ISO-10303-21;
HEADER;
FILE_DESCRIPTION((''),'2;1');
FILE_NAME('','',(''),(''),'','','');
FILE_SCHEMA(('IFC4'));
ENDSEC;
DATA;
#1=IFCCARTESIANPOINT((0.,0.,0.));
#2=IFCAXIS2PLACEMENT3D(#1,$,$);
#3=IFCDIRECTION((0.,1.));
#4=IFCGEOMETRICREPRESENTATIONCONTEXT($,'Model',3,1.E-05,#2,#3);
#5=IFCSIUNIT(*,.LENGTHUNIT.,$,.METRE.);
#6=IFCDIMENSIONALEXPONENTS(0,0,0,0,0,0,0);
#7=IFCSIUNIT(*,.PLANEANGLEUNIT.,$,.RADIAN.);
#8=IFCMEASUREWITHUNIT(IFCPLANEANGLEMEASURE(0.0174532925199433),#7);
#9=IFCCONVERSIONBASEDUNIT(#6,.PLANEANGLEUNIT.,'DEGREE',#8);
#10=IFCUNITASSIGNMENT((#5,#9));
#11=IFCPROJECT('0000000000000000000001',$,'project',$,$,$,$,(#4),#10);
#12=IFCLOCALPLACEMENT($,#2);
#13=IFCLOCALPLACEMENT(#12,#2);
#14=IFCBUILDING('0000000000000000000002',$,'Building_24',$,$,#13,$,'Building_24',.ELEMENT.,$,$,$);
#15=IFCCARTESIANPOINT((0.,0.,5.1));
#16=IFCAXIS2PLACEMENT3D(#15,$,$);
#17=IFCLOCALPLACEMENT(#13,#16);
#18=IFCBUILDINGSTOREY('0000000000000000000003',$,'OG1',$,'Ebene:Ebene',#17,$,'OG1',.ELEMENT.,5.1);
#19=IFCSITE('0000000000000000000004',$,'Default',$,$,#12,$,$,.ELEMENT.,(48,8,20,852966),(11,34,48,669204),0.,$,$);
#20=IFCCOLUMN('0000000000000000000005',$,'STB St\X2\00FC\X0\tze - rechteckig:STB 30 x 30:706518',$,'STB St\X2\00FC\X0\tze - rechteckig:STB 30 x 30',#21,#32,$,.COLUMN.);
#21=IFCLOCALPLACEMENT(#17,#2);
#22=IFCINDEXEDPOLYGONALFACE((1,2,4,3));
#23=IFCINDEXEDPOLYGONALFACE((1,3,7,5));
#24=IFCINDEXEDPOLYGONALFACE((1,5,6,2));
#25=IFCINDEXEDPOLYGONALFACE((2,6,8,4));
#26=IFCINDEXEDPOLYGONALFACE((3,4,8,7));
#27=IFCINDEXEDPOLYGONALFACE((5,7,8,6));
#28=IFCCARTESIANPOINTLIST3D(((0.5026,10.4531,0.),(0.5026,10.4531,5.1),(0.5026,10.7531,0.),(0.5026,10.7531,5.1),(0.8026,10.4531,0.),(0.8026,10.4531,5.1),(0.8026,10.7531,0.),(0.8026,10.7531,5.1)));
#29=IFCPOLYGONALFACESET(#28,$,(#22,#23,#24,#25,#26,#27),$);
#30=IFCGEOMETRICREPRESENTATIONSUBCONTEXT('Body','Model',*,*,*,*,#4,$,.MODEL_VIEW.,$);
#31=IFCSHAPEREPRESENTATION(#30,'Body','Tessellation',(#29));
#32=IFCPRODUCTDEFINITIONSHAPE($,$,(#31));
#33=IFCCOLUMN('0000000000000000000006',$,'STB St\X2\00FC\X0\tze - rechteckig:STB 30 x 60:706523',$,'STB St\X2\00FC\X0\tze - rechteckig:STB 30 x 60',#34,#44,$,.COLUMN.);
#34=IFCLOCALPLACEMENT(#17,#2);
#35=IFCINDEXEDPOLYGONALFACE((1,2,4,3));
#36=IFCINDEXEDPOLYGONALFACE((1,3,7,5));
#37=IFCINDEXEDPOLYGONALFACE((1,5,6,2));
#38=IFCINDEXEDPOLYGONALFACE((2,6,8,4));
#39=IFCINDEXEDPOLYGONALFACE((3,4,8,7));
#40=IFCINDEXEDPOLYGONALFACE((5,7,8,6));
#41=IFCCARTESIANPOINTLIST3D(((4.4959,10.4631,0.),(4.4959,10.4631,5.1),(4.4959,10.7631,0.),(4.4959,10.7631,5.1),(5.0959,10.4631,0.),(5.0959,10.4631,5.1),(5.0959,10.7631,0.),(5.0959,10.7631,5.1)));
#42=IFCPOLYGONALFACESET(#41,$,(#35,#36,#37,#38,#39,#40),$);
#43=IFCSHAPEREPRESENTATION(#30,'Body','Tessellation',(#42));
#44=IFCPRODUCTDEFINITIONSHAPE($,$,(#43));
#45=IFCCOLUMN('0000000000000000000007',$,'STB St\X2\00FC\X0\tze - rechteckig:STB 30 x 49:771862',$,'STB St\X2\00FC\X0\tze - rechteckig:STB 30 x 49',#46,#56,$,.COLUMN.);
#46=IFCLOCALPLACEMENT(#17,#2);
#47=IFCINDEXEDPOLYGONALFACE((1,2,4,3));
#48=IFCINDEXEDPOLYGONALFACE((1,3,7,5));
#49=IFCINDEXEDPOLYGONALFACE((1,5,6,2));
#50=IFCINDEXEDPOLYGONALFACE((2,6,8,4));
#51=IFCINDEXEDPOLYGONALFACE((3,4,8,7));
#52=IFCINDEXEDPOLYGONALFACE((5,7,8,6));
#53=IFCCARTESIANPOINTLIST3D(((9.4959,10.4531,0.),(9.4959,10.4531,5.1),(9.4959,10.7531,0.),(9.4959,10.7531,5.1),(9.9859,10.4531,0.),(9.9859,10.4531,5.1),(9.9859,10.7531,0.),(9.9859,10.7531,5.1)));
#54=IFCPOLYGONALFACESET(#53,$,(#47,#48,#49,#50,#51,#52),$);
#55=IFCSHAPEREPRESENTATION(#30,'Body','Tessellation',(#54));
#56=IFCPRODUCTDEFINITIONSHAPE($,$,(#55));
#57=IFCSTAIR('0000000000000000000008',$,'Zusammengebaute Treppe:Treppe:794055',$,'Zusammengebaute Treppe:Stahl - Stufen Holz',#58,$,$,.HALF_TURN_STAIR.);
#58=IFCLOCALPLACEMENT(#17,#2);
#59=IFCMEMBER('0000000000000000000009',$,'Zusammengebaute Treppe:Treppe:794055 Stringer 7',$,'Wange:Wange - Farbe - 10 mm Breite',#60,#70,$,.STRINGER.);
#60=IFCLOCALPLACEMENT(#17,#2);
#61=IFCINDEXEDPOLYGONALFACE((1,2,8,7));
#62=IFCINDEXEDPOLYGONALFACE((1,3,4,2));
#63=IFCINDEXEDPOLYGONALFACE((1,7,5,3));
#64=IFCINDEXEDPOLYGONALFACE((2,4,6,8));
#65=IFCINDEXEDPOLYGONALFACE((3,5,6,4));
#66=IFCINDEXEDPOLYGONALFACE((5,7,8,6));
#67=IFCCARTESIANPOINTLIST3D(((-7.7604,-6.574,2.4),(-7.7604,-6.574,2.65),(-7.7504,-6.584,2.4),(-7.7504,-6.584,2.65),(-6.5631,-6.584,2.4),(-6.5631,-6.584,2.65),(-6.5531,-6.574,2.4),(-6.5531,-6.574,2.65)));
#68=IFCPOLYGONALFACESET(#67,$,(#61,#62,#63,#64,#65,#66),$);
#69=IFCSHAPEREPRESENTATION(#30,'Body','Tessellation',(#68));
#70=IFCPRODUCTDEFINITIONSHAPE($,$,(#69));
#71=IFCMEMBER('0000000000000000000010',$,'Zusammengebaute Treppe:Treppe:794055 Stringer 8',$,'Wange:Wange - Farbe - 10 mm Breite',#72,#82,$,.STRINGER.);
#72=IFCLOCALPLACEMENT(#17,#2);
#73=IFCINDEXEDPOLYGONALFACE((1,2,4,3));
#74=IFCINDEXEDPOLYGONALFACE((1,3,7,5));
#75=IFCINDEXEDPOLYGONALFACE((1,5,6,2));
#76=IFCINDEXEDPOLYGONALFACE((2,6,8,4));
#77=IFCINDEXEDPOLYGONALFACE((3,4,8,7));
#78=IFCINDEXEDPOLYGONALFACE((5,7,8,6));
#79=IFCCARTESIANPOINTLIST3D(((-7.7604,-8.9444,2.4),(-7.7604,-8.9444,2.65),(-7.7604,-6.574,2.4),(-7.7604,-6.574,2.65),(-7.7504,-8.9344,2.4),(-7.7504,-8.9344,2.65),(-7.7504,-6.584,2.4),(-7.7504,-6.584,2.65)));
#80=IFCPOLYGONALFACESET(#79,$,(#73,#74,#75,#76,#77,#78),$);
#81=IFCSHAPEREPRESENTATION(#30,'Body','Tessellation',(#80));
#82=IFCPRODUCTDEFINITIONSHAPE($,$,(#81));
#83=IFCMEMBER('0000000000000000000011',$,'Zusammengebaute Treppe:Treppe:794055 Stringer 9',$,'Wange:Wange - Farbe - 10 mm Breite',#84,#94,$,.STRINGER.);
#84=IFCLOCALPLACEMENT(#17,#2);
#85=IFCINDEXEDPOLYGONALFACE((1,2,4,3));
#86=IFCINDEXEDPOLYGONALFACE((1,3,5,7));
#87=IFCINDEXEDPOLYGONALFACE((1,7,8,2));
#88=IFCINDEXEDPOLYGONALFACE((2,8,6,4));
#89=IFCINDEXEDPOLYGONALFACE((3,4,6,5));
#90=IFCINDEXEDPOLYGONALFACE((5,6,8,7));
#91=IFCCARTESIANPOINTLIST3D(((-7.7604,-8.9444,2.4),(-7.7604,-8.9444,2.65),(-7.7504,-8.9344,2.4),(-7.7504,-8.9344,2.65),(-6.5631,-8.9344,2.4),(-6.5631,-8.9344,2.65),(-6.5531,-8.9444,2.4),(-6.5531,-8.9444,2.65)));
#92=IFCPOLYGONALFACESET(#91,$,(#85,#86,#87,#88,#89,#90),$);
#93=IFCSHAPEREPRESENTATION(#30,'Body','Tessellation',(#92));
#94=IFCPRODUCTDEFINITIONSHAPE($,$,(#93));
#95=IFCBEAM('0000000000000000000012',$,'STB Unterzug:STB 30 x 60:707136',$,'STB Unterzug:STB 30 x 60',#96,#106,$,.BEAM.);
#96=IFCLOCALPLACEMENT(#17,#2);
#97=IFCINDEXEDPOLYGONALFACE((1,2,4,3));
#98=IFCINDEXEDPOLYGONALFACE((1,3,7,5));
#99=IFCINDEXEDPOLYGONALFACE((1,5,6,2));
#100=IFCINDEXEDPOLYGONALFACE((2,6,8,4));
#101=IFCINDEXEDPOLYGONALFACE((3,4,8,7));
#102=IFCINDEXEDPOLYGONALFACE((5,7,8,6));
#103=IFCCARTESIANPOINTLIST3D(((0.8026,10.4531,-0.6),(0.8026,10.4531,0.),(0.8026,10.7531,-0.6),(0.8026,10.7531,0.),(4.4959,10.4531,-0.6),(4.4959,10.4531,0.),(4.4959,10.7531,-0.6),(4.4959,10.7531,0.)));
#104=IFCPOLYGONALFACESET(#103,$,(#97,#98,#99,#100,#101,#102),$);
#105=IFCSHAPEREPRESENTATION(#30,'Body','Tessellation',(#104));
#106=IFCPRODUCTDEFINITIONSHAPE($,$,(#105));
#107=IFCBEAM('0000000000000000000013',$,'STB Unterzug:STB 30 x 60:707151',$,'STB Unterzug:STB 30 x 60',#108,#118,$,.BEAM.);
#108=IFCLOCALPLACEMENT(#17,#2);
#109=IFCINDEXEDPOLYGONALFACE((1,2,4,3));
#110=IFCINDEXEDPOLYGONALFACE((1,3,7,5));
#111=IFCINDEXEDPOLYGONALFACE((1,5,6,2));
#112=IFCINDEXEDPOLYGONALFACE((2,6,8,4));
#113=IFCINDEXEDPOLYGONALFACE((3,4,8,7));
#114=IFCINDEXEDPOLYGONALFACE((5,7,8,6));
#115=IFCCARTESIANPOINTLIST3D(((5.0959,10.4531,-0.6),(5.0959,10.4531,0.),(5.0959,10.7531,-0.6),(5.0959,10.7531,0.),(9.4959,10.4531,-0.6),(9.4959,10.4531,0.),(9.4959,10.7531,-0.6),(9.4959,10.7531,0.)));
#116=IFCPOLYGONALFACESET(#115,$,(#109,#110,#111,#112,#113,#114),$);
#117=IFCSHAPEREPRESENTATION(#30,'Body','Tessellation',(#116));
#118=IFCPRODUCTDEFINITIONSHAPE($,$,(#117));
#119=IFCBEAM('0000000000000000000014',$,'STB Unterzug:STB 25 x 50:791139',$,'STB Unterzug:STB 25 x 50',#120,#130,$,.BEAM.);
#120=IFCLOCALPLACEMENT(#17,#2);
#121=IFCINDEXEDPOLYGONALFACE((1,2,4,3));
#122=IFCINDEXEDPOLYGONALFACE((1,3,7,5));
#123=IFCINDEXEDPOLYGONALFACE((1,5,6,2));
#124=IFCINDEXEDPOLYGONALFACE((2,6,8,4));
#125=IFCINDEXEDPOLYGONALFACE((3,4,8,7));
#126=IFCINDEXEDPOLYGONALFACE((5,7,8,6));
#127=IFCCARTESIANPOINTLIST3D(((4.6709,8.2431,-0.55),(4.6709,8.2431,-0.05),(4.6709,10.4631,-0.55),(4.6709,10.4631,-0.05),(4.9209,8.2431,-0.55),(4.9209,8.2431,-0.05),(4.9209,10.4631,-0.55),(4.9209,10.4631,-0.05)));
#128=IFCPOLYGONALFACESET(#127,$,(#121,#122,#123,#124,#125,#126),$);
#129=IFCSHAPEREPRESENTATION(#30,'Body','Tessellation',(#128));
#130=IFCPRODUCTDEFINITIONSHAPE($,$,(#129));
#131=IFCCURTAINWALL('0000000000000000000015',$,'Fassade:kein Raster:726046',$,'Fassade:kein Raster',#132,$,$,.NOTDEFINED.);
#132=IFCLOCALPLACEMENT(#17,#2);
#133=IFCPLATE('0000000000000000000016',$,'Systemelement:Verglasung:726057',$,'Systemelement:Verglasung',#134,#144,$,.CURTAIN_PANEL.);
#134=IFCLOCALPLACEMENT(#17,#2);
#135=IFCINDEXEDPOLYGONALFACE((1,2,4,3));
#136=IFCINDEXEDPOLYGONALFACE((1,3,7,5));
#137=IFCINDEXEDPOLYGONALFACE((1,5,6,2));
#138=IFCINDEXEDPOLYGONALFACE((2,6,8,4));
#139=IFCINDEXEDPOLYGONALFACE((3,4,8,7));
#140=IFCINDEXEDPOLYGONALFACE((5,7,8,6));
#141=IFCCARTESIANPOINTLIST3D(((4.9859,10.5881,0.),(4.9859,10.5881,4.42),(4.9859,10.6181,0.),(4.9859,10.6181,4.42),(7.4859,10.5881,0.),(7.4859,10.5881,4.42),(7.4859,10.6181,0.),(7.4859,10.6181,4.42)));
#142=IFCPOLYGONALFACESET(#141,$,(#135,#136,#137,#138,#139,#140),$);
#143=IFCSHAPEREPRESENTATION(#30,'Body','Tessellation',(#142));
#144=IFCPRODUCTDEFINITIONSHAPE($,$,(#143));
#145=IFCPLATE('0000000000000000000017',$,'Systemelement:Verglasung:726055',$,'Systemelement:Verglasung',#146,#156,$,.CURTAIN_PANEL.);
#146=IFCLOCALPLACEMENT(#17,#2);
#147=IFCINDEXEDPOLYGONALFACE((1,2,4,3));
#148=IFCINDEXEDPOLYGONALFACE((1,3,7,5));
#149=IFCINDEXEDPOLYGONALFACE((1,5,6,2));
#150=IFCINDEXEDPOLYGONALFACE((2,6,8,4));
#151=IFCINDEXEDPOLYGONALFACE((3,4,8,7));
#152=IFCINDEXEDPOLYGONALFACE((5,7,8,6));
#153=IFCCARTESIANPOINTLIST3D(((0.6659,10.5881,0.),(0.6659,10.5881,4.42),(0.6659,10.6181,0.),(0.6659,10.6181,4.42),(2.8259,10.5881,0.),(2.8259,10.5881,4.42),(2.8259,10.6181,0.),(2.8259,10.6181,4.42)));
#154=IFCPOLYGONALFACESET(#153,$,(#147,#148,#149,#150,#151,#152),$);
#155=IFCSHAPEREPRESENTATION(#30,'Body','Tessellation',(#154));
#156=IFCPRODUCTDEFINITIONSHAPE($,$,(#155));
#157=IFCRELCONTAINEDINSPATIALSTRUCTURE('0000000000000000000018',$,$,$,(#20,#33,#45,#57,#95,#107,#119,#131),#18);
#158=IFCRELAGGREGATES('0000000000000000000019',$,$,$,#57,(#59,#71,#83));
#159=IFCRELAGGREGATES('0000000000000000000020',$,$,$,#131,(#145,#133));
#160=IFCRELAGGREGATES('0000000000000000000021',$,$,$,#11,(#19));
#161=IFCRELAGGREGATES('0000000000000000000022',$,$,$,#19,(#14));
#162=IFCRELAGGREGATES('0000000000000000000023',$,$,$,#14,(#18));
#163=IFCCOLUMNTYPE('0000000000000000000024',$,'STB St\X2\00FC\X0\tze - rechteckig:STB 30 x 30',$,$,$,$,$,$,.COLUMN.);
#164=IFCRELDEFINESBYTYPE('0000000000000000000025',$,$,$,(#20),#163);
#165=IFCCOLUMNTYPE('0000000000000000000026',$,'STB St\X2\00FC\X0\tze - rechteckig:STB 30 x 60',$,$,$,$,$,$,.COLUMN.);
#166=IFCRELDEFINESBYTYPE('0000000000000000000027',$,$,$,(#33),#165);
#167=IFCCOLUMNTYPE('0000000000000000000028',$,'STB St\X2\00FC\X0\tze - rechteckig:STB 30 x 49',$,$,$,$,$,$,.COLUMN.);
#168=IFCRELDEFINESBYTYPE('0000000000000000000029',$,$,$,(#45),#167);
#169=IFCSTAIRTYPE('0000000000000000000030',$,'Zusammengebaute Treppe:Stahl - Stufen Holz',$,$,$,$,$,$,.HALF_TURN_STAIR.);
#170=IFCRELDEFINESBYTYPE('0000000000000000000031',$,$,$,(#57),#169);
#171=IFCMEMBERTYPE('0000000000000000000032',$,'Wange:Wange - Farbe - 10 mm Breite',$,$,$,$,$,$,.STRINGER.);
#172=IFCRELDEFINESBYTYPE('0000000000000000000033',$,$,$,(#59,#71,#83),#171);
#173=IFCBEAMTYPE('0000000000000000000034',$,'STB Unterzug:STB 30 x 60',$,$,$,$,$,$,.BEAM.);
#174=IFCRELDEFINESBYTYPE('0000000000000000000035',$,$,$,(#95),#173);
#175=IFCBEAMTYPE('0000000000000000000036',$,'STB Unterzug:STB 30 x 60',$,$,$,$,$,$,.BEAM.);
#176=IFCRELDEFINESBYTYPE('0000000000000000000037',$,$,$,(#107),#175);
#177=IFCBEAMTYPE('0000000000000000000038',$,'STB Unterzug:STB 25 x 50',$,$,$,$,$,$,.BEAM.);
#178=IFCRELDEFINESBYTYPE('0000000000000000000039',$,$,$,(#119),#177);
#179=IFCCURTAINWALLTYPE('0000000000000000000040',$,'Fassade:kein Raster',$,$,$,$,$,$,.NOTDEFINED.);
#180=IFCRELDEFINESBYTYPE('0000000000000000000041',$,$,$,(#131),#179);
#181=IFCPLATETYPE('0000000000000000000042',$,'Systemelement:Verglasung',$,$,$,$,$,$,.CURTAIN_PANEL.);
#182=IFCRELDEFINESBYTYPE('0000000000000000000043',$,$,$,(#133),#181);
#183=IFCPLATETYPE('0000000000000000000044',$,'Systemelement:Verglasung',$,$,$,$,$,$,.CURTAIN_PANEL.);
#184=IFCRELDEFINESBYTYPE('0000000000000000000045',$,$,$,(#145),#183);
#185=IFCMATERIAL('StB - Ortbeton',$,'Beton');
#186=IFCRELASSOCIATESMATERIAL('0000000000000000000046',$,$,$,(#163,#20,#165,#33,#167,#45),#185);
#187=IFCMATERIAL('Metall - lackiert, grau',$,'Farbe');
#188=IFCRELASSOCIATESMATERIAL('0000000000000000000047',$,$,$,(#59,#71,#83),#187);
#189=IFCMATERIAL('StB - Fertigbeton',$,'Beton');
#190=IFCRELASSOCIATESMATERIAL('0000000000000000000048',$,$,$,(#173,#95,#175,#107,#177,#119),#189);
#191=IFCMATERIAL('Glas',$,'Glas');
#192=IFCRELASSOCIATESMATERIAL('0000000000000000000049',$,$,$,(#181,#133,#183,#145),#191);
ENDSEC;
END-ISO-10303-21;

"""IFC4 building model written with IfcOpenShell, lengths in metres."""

from ifc_helpers import new_model, entity, si_unit, converted_unit, direction, frame, origin, place, context, subcontext, project, spatial, indexed_curve, outline, extrude, source, transform, mapped, material, type_object, type_shapes, element, aggregate, save


model = new_model("IFC4")

# Units and contexts
model_context = context("Model", 3, precision=1e-05, world=origin(), true_north=direction((0.0, 1.0)))
body_context = subcontext(model_context, "Body", "Model", "MODEL_VIEW")
ifc_project = project(units=[si_unit("LENGTHUNIT", "METRE"), converted_unit("PLANEANGLEUNIT", "DEGREE", entity("IfcPlaneAngleMeasure", 0.0174532925199433), si_unit("PLANEANGLEUNIT", "RADIAN"), dimensions=[0, 0, 0, 0, 0, 0, 0])], contexts=[model_context])

# Site, building, storey
site_placement = place(None, origin())
site = spatial("IfcSite", under=ifc_project, at=site_placement, Name="Default", CompositionType="ELEMENT", RefLatitude=(48, 8, 20, 852966), RefLongitude=(11, 34, 48, 669204), RefElevation=0.0)
building_placement = place(site_placement, origin())
building = spatial("IfcBuilding", under=site, at=building_placement, Name="Building_24", LongName="Building_24", CompositionType="ELEMENT")
storey_placement = place(building_placement, frame((0.0, 0.0, 5.1)))
storey = spatial("IfcBuildingStorey", under=building, at=storey_placement, Name="OG1", ObjectType="Ebene:Ebene", LongName="OG1", CompositionType="ELEMENT", Elevation=5.1)

# Columns
ifc_material_1 = material(Name="StB - Ortbeton", Category="Beton")
column_type_1 = type_object("IfcColumnType", Name="STB Stütze - rechteckig:STB 30 x 30", PredefinedType="COLUMN", material=ifc_material_1)
shared_shape_1 = source(origin(), body_context, "Body", "SweptSolid", [
    extrude(outline(indexed_curve([(-0.15, -0.15), (0.15, -0.15), (0.15, 0.15), (-0.15, 0.15), (-0.15, -0.15)], self_intersect=False)), frame((0.0, 0.0, 5.1), z_axis=(0.0, 0.0, 1.0), x_axis=(-1.0, 0.0, 0.0)), (0.0, 0.0, 1.0), 5.1),
])
type_shapes(column_type_1, [shared_shape_1])
column_1_placement = place(storey_placement, frame((0.6526, 10.6031, -5.1)))
element("IfcColumn", 1, at=column_1_placement, inside=storey, type_object=column_type_1, material=ifc_material_1, Name="STB Stütze - rechteckig:STB 30 x 30:706518", ObjectType="STB Stütze - rechteckig:STB 30 x 30", PredefinedType="COLUMN", context=body_context, shape_type="MappedRepresentation", body=[
    mapped(shared_shape_1, transform((0.0, 0.0, 0.0), scale=1.0)),
])
column_type_2 = type_object("IfcColumnType", Name="STB Stütze - rechteckig:STB 30 x 60", PredefinedType="COLUMN", material=ifc_material_1)
shared_shape_2 = source(origin(), body_context, "Body", "SweptSolid", [
    extrude(outline(indexed_curve([(-0.3, -0.15), (0.3, -0.15), (0.3, 0.15), (-0.3, 0.15), (-0.3, -0.15)], self_intersect=False)), frame((0.0, 0.0, 5.1), z_axis=(0.0, 0.0, 1.0), x_axis=(-1.0, 0.0, 0.0)), (0.0, 0.0, 1.0), 5.1),
])
type_shapes(column_type_2, [shared_shape_2])
column_2_placement = place(storey_placement, frame((4.7959, 10.6131, -5.1)))
element("IfcColumn", 2, at=column_2_placement, inside=storey, type_object=column_type_2, material=ifc_material_1, Name="STB Stütze - rechteckig:STB 30 x 60:706523", ObjectType="STB Stütze - rechteckig:STB 30 x 60", PredefinedType="COLUMN", context=body_context, shape_type="MappedRepresentation", body=[
    mapped(shared_shape_2, transform((0.0, 0.0, 0.0), scale=1.0)),
])
column_type_3 = type_object("IfcColumnType", Name="STB Stütze - rechteckig:STB 30 x 49", PredefinedType="COLUMN", material=ifc_material_1)
shared_shape_3 = source(origin(), body_context, "Body", "SweptSolid", [
    extrude(outline(indexed_curve([(-0.245, -0.15), (0.245, -0.15), (0.245, 0.15), (-0.245, 0.15), (-0.245, -0.15)], self_intersect=False)), frame((0.0, 0.0, 5.1), z_axis=(0.0, 0.0, 1.0), x_axis=(-1.0, 0.0, 0.0)), (0.0, 0.0, 1.0), 5.1),
])
type_shapes(column_type_3, [shared_shape_3])
column_3_placement = place(storey_placement, frame((9.7409, 10.6031, -5.1)))
element("IfcColumn", 3, at=column_3_placement, inside=storey, type_object=column_type_3, material=ifc_material_1, Name="STB Stütze - rechteckig:STB 30 x 49:771862", ObjectType="STB Stütze - rechteckig:STB 30 x 49", PredefinedType="COLUMN", context=body_context, shape_type="MappedRepresentation", body=[
    mapped(shared_shape_3, transform((0.0, 0.0, 0.0), scale=1.0)),
])

# Stair, members
stair_type = type_object("IfcStairType", Name="Zusammengebaute Treppe:Stahl - Stufen Holz", PredefinedType="HALF_TURN_STAIR")
stair_placement = place(storey_placement, origin())
stair = element("IfcStair", 4, at=stair_placement, inside=storey, type_object=stair_type, Name="Zusammengebaute Treppe:Treppe:794055", ObjectType="Zusammengebaute Treppe:Stahl - Stufen Holz", PredefinedType="HALF_TURN_STAIR")
ifc_material_2 = material(Name="Metall - lackiert, grau", Category="Farbe")
member_type = type_object("IfcMemberType", Name="Wange:Wange - Farbe - 10 mm Breite", PredefinedType="STRINGER")
member_1_placement = place(stair_placement, origin())
member_1 = element("IfcMember", 5, at=member_1_placement, type_object=member_type, material=ifc_material_2, Name="Zusammengebaute Treppe:Treppe:794055 Stringer 7", ObjectType="Wange:Wange - Farbe - 10 mm Breite", PredefinedType="STRINGER", context=body_context, shape_type="SweptSolid", body=[
    extrude(outline(indexed_curve([(-0.6037, -0.005), (0.6037, -0.005), (0.5937, 0.005), (-0.5937, 0.005), (-0.6037, -0.005)], self_intersect=False)), frame((-7.1568, -6.579, 2.4), z_axis=(0.0, 0.0, 1.0), x_axis=(-1.0, 0.0, 0.0)), (0.0, 0.0, 1.0), 0.25),
])
member_2_placement = place(stair_placement, origin())
member_2 = element("IfcMember", 6, at=member_2_placement, type_object=member_type, material=ifc_material_2, Name="Zusammengebaute Treppe:Treppe:794055 Stringer 8", ObjectType="Wange:Wange - Farbe - 10 mm Breite", PredefinedType="STRINGER", context=body_context, shape_type="SweptSolid", body=[
    extrude(outline(indexed_curve([(-1.1852, -0.005), (1.1852, -0.005), (1.1752, 0.005), (-1.1752, 0.005), (-1.1852, -0.005)], self_intersect=False)), frame((-7.7554, -7.7592, 2.4), z_axis=(0.0, 0.0, 1.0), x_axis=(0.0, -1.0, 0.0)), (0.0, 0.0, 1.0), 0.25),
])
member_3_placement = place(stair_placement, origin())
member_3 = element("IfcMember", 7, at=member_3_placement, type_object=member_type, material=ifc_material_2, Name="Zusammengebaute Treppe:Treppe:794055 Stringer 9", ObjectType="Wange:Wange - Farbe - 10 mm Breite", PredefinedType="STRINGER", context=body_context, shape_type="SweptSolid", body=[
    extrude(outline(indexed_curve([(-0.6037, -0.005), (0.6037, -0.005), (0.5937, 0.005), (-0.5937, 0.005), (-0.6037, -0.005)], self_intersect=False)), frame((-7.1568, -8.9394, 2.4)), (0.0, 0.0, 1.0), 0.25),
])
aggregate(stair, [member_1, member_2, member_3])

# Beams
ifc_material_3 = material(Name="StB - Fertigbeton", Category="Beton")
beam_type_1 = type_object("IfcBeamType", Name="STB Unterzug:STB 30 x 60", PredefinedType="BEAM", material=ifc_material_3)
shared_shape_4 = source(origin(), body_context, "Body", "SweptSolid", [
    extrude(outline(indexed_curve([(-1.8467, -0.15), (1.8467, -0.15), (1.8467, 0.15), (-1.8467, 0.15), (-1.8467, -0.15)], self_intersect=False)), frame((-0.18, 0.0, -0.3), z_axis=(0.0, 0.0, 1.0), x_axis=(-1.0, 0.0, 0.0)), (0.0, 0.0, 1.0), 0.6),
])
type_shapes(beam_type_1, [shared_shape_4])
beam_1_placement = place(storey_placement, frame((2.8293, 10.6031, -0.3)))
element("IfcBeam", 8, at=beam_1_placement, inside=storey, type_object=beam_type_1, material=ifc_material_3, Name="STB Unterzug:STB 30 x 60:707136", ObjectType="STB Unterzug:STB 30 x 60", PredefinedType="BEAM", context=body_context, shape_type="MappedRepresentation", body=[
    mapped(shared_shape_4, transform((0.0, 0.0, 0.0), scale=1.0)),
])
beam_type_2 = type_object("IfcBeamType", Name="STB Unterzug:STB 30 x 60", PredefinedType="BEAM", material=ifc_material_3)
shared_shape_5 = source(origin(), body_context, "Body", "SweptSolid", [
    extrude(outline(indexed_curve([(-2.2, -0.15), (2.2, -0.15), (2.2, 0.15), (-2.2, 0.15), (-2.2, -0.15)], self_intersect=False)), frame((-0.0675, 0.0, -0.3), z_axis=(0.0, 0.0, 1.0), x_axis=(-1.0, 0.0, 0.0)), (0.0, 0.0, 1.0), 0.6),
])
type_shapes(beam_type_2, [shared_shape_5])
beam_2_placement = place(storey_placement, frame((7.3634, 10.6031, -0.3)))
element("IfcBeam", 9, at=beam_2_placement, inside=storey, type_object=beam_type_2, material=ifc_material_3, Name="STB Unterzug:STB 30 x 60:707151", ObjectType="STB Unterzug:STB 30 x 60", PredefinedType="BEAM", context=body_context, shape_type="MappedRepresentation", body=[
    mapped(shared_shape_5, transform((0.0, 0.0, 0.0), scale=1.0)),
])
beam_type_3 = type_object("IfcBeamType", Name="STB Unterzug:STB 25 x 50", PredefinedType="BEAM", material=ifc_material_3)
shared_shape_6 = source(origin(), body_context, "Body", "SweptSolid", [
    extrude(outline(indexed_curve([(-1.11, -0.125), (1.11, -0.125), (1.11, 0.125), (-1.11, 0.125), (-1.11, -0.125)], self_intersect=False)), frame((-0.0475, 0.0, -0.25), z_axis=(0.0, 0.0, 1.0), x_axis=(-1.0, 0.0, 0.0)), (0.0, 0.0, 1.0), 0.5),
])
type_shapes(beam_type_3, [shared_shape_6])
beam_3_placement = place(storey_placement, frame((4.7959, 9.3056, -0.3), z_axis=(0.0, 0.0, 1.0), x_axis=(0.0, -1.0, 0.0)))
element("IfcBeam", 10, at=beam_3_placement, inside=storey, type_object=beam_type_3, material=ifc_material_3, Name="STB Unterzug:STB 25 x 50:791139", ObjectType="STB Unterzug:STB 25 x 50", PredefinedType="BEAM", context=body_context, shape_type="MappedRepresentation", body=[
    mapped(shared_shape_6, transform((0.0, 0.0, 0.0), scale=1.0)),
])

# Curtain wall, plates
curtain_wall_type = type_object("IfcCurtainWallType", Name="Fassade:kein Raster", PredefinedType="NOTDEFINED")
curtain_wall_placement = place(storey_placement, frame((0.0, 0.0, -5.1)))
curtain_wall = element("IfcCurtainWall", 11, at=curtain_wall_placement, inside=storey, type_object=curtain_wall_type, Name="Fassade:kein Raster:726046", ObjectType="Fassade:kein Raster", PredefinedType="NOTDEFINED")
ifc_material_4 = material(Name="Glas", Category="Glas")
plate_type_1 = type_object("IfcPlateType", Name="Systemelement:Verglasung", PredefinedType="CURTAIN_PANEL", material=ifc_material_4)
shared_shape_7 = source(origin(), body_context, "Body", "SweptSolid", [
    extrude(outline(indexed_curve([(-0.015, -1.25), (0.015, -1.25), (0.015, 1.25), (-0.015, 1.25), (-0.015, -1.25)], self_intersect=False)), frame((0.0, 0.0, 0.0), z_axis=(0.0, 0.0, 1.0), x_axis=(0.0, 1.0, 0.0)), (0.0, 0.0, 1.0), 4.42),
])
type_shapes(plate_type_1, [shared_shape_7])
plate_1_placement = place(curtain_wall_placement, frame((6.2359, 10.6031, 5.1)))
plate_1 = element("IfcPlate", 12, at=plate_1_placement, type_object=plate_type_1, material=ifc_material_4, Name="Systemelement:Verglasung:726057", ObjectType="Systemelement:Verglasung", PredefinedType="CURTAIN_PANEL", context=body_context, shape_type="MappedRepresentation", body=[
    mapped(shared_shape_7, transform((0.0, 0.0, 0.0), scale=1.0)),
])
plate_type_2 = type_object("IfcPlateType", Name="Systemelement:Verglasung", PredefinedType="CURTAIN_PANEL", material=ifc_material_4)
shared_shape_8 = source(origin(), body_context, "Body", "SweptSolid", [
    extrude(outline(indexed_curve([(-0.015, -1.08), (0.015, -1.08), (0.015, 1.08), (-0.015, 1.08), (-0.015, -1.08)], self_intersect=False)), frame((0.0, 0.0, 0.0), z_axis=(0.0, 0.0, 1.0), x_axis=(0.0, 1.0, 0.0)), (0.0, 0.0, 1.0), 4.42),
])
type_shapes(plate_type_2, [shared_shape_8])
plate_2_placement = place(curtain_wall_placement, frame((1.7459, 10.6031, 5.1)))
plate_2 = element("IfcPlate", 13, at=plate_2_placement, type_object=plate_type_2, material=ifc_material_4, Name="Systemelement:Verglasung:726055", ObjectType="Systemelement:Verglasung", PredefinedType="CURTAIN_PANEL", context=body_context, shape_type="MappedRepresentation", body=[
    mapped(shared_shape_8, transform((0.0, 0.0, 0.0), scale=1.0)),
])
aggregate(curtain_wall, [plate_2, plate_1])

save(model, "model.ifc")
